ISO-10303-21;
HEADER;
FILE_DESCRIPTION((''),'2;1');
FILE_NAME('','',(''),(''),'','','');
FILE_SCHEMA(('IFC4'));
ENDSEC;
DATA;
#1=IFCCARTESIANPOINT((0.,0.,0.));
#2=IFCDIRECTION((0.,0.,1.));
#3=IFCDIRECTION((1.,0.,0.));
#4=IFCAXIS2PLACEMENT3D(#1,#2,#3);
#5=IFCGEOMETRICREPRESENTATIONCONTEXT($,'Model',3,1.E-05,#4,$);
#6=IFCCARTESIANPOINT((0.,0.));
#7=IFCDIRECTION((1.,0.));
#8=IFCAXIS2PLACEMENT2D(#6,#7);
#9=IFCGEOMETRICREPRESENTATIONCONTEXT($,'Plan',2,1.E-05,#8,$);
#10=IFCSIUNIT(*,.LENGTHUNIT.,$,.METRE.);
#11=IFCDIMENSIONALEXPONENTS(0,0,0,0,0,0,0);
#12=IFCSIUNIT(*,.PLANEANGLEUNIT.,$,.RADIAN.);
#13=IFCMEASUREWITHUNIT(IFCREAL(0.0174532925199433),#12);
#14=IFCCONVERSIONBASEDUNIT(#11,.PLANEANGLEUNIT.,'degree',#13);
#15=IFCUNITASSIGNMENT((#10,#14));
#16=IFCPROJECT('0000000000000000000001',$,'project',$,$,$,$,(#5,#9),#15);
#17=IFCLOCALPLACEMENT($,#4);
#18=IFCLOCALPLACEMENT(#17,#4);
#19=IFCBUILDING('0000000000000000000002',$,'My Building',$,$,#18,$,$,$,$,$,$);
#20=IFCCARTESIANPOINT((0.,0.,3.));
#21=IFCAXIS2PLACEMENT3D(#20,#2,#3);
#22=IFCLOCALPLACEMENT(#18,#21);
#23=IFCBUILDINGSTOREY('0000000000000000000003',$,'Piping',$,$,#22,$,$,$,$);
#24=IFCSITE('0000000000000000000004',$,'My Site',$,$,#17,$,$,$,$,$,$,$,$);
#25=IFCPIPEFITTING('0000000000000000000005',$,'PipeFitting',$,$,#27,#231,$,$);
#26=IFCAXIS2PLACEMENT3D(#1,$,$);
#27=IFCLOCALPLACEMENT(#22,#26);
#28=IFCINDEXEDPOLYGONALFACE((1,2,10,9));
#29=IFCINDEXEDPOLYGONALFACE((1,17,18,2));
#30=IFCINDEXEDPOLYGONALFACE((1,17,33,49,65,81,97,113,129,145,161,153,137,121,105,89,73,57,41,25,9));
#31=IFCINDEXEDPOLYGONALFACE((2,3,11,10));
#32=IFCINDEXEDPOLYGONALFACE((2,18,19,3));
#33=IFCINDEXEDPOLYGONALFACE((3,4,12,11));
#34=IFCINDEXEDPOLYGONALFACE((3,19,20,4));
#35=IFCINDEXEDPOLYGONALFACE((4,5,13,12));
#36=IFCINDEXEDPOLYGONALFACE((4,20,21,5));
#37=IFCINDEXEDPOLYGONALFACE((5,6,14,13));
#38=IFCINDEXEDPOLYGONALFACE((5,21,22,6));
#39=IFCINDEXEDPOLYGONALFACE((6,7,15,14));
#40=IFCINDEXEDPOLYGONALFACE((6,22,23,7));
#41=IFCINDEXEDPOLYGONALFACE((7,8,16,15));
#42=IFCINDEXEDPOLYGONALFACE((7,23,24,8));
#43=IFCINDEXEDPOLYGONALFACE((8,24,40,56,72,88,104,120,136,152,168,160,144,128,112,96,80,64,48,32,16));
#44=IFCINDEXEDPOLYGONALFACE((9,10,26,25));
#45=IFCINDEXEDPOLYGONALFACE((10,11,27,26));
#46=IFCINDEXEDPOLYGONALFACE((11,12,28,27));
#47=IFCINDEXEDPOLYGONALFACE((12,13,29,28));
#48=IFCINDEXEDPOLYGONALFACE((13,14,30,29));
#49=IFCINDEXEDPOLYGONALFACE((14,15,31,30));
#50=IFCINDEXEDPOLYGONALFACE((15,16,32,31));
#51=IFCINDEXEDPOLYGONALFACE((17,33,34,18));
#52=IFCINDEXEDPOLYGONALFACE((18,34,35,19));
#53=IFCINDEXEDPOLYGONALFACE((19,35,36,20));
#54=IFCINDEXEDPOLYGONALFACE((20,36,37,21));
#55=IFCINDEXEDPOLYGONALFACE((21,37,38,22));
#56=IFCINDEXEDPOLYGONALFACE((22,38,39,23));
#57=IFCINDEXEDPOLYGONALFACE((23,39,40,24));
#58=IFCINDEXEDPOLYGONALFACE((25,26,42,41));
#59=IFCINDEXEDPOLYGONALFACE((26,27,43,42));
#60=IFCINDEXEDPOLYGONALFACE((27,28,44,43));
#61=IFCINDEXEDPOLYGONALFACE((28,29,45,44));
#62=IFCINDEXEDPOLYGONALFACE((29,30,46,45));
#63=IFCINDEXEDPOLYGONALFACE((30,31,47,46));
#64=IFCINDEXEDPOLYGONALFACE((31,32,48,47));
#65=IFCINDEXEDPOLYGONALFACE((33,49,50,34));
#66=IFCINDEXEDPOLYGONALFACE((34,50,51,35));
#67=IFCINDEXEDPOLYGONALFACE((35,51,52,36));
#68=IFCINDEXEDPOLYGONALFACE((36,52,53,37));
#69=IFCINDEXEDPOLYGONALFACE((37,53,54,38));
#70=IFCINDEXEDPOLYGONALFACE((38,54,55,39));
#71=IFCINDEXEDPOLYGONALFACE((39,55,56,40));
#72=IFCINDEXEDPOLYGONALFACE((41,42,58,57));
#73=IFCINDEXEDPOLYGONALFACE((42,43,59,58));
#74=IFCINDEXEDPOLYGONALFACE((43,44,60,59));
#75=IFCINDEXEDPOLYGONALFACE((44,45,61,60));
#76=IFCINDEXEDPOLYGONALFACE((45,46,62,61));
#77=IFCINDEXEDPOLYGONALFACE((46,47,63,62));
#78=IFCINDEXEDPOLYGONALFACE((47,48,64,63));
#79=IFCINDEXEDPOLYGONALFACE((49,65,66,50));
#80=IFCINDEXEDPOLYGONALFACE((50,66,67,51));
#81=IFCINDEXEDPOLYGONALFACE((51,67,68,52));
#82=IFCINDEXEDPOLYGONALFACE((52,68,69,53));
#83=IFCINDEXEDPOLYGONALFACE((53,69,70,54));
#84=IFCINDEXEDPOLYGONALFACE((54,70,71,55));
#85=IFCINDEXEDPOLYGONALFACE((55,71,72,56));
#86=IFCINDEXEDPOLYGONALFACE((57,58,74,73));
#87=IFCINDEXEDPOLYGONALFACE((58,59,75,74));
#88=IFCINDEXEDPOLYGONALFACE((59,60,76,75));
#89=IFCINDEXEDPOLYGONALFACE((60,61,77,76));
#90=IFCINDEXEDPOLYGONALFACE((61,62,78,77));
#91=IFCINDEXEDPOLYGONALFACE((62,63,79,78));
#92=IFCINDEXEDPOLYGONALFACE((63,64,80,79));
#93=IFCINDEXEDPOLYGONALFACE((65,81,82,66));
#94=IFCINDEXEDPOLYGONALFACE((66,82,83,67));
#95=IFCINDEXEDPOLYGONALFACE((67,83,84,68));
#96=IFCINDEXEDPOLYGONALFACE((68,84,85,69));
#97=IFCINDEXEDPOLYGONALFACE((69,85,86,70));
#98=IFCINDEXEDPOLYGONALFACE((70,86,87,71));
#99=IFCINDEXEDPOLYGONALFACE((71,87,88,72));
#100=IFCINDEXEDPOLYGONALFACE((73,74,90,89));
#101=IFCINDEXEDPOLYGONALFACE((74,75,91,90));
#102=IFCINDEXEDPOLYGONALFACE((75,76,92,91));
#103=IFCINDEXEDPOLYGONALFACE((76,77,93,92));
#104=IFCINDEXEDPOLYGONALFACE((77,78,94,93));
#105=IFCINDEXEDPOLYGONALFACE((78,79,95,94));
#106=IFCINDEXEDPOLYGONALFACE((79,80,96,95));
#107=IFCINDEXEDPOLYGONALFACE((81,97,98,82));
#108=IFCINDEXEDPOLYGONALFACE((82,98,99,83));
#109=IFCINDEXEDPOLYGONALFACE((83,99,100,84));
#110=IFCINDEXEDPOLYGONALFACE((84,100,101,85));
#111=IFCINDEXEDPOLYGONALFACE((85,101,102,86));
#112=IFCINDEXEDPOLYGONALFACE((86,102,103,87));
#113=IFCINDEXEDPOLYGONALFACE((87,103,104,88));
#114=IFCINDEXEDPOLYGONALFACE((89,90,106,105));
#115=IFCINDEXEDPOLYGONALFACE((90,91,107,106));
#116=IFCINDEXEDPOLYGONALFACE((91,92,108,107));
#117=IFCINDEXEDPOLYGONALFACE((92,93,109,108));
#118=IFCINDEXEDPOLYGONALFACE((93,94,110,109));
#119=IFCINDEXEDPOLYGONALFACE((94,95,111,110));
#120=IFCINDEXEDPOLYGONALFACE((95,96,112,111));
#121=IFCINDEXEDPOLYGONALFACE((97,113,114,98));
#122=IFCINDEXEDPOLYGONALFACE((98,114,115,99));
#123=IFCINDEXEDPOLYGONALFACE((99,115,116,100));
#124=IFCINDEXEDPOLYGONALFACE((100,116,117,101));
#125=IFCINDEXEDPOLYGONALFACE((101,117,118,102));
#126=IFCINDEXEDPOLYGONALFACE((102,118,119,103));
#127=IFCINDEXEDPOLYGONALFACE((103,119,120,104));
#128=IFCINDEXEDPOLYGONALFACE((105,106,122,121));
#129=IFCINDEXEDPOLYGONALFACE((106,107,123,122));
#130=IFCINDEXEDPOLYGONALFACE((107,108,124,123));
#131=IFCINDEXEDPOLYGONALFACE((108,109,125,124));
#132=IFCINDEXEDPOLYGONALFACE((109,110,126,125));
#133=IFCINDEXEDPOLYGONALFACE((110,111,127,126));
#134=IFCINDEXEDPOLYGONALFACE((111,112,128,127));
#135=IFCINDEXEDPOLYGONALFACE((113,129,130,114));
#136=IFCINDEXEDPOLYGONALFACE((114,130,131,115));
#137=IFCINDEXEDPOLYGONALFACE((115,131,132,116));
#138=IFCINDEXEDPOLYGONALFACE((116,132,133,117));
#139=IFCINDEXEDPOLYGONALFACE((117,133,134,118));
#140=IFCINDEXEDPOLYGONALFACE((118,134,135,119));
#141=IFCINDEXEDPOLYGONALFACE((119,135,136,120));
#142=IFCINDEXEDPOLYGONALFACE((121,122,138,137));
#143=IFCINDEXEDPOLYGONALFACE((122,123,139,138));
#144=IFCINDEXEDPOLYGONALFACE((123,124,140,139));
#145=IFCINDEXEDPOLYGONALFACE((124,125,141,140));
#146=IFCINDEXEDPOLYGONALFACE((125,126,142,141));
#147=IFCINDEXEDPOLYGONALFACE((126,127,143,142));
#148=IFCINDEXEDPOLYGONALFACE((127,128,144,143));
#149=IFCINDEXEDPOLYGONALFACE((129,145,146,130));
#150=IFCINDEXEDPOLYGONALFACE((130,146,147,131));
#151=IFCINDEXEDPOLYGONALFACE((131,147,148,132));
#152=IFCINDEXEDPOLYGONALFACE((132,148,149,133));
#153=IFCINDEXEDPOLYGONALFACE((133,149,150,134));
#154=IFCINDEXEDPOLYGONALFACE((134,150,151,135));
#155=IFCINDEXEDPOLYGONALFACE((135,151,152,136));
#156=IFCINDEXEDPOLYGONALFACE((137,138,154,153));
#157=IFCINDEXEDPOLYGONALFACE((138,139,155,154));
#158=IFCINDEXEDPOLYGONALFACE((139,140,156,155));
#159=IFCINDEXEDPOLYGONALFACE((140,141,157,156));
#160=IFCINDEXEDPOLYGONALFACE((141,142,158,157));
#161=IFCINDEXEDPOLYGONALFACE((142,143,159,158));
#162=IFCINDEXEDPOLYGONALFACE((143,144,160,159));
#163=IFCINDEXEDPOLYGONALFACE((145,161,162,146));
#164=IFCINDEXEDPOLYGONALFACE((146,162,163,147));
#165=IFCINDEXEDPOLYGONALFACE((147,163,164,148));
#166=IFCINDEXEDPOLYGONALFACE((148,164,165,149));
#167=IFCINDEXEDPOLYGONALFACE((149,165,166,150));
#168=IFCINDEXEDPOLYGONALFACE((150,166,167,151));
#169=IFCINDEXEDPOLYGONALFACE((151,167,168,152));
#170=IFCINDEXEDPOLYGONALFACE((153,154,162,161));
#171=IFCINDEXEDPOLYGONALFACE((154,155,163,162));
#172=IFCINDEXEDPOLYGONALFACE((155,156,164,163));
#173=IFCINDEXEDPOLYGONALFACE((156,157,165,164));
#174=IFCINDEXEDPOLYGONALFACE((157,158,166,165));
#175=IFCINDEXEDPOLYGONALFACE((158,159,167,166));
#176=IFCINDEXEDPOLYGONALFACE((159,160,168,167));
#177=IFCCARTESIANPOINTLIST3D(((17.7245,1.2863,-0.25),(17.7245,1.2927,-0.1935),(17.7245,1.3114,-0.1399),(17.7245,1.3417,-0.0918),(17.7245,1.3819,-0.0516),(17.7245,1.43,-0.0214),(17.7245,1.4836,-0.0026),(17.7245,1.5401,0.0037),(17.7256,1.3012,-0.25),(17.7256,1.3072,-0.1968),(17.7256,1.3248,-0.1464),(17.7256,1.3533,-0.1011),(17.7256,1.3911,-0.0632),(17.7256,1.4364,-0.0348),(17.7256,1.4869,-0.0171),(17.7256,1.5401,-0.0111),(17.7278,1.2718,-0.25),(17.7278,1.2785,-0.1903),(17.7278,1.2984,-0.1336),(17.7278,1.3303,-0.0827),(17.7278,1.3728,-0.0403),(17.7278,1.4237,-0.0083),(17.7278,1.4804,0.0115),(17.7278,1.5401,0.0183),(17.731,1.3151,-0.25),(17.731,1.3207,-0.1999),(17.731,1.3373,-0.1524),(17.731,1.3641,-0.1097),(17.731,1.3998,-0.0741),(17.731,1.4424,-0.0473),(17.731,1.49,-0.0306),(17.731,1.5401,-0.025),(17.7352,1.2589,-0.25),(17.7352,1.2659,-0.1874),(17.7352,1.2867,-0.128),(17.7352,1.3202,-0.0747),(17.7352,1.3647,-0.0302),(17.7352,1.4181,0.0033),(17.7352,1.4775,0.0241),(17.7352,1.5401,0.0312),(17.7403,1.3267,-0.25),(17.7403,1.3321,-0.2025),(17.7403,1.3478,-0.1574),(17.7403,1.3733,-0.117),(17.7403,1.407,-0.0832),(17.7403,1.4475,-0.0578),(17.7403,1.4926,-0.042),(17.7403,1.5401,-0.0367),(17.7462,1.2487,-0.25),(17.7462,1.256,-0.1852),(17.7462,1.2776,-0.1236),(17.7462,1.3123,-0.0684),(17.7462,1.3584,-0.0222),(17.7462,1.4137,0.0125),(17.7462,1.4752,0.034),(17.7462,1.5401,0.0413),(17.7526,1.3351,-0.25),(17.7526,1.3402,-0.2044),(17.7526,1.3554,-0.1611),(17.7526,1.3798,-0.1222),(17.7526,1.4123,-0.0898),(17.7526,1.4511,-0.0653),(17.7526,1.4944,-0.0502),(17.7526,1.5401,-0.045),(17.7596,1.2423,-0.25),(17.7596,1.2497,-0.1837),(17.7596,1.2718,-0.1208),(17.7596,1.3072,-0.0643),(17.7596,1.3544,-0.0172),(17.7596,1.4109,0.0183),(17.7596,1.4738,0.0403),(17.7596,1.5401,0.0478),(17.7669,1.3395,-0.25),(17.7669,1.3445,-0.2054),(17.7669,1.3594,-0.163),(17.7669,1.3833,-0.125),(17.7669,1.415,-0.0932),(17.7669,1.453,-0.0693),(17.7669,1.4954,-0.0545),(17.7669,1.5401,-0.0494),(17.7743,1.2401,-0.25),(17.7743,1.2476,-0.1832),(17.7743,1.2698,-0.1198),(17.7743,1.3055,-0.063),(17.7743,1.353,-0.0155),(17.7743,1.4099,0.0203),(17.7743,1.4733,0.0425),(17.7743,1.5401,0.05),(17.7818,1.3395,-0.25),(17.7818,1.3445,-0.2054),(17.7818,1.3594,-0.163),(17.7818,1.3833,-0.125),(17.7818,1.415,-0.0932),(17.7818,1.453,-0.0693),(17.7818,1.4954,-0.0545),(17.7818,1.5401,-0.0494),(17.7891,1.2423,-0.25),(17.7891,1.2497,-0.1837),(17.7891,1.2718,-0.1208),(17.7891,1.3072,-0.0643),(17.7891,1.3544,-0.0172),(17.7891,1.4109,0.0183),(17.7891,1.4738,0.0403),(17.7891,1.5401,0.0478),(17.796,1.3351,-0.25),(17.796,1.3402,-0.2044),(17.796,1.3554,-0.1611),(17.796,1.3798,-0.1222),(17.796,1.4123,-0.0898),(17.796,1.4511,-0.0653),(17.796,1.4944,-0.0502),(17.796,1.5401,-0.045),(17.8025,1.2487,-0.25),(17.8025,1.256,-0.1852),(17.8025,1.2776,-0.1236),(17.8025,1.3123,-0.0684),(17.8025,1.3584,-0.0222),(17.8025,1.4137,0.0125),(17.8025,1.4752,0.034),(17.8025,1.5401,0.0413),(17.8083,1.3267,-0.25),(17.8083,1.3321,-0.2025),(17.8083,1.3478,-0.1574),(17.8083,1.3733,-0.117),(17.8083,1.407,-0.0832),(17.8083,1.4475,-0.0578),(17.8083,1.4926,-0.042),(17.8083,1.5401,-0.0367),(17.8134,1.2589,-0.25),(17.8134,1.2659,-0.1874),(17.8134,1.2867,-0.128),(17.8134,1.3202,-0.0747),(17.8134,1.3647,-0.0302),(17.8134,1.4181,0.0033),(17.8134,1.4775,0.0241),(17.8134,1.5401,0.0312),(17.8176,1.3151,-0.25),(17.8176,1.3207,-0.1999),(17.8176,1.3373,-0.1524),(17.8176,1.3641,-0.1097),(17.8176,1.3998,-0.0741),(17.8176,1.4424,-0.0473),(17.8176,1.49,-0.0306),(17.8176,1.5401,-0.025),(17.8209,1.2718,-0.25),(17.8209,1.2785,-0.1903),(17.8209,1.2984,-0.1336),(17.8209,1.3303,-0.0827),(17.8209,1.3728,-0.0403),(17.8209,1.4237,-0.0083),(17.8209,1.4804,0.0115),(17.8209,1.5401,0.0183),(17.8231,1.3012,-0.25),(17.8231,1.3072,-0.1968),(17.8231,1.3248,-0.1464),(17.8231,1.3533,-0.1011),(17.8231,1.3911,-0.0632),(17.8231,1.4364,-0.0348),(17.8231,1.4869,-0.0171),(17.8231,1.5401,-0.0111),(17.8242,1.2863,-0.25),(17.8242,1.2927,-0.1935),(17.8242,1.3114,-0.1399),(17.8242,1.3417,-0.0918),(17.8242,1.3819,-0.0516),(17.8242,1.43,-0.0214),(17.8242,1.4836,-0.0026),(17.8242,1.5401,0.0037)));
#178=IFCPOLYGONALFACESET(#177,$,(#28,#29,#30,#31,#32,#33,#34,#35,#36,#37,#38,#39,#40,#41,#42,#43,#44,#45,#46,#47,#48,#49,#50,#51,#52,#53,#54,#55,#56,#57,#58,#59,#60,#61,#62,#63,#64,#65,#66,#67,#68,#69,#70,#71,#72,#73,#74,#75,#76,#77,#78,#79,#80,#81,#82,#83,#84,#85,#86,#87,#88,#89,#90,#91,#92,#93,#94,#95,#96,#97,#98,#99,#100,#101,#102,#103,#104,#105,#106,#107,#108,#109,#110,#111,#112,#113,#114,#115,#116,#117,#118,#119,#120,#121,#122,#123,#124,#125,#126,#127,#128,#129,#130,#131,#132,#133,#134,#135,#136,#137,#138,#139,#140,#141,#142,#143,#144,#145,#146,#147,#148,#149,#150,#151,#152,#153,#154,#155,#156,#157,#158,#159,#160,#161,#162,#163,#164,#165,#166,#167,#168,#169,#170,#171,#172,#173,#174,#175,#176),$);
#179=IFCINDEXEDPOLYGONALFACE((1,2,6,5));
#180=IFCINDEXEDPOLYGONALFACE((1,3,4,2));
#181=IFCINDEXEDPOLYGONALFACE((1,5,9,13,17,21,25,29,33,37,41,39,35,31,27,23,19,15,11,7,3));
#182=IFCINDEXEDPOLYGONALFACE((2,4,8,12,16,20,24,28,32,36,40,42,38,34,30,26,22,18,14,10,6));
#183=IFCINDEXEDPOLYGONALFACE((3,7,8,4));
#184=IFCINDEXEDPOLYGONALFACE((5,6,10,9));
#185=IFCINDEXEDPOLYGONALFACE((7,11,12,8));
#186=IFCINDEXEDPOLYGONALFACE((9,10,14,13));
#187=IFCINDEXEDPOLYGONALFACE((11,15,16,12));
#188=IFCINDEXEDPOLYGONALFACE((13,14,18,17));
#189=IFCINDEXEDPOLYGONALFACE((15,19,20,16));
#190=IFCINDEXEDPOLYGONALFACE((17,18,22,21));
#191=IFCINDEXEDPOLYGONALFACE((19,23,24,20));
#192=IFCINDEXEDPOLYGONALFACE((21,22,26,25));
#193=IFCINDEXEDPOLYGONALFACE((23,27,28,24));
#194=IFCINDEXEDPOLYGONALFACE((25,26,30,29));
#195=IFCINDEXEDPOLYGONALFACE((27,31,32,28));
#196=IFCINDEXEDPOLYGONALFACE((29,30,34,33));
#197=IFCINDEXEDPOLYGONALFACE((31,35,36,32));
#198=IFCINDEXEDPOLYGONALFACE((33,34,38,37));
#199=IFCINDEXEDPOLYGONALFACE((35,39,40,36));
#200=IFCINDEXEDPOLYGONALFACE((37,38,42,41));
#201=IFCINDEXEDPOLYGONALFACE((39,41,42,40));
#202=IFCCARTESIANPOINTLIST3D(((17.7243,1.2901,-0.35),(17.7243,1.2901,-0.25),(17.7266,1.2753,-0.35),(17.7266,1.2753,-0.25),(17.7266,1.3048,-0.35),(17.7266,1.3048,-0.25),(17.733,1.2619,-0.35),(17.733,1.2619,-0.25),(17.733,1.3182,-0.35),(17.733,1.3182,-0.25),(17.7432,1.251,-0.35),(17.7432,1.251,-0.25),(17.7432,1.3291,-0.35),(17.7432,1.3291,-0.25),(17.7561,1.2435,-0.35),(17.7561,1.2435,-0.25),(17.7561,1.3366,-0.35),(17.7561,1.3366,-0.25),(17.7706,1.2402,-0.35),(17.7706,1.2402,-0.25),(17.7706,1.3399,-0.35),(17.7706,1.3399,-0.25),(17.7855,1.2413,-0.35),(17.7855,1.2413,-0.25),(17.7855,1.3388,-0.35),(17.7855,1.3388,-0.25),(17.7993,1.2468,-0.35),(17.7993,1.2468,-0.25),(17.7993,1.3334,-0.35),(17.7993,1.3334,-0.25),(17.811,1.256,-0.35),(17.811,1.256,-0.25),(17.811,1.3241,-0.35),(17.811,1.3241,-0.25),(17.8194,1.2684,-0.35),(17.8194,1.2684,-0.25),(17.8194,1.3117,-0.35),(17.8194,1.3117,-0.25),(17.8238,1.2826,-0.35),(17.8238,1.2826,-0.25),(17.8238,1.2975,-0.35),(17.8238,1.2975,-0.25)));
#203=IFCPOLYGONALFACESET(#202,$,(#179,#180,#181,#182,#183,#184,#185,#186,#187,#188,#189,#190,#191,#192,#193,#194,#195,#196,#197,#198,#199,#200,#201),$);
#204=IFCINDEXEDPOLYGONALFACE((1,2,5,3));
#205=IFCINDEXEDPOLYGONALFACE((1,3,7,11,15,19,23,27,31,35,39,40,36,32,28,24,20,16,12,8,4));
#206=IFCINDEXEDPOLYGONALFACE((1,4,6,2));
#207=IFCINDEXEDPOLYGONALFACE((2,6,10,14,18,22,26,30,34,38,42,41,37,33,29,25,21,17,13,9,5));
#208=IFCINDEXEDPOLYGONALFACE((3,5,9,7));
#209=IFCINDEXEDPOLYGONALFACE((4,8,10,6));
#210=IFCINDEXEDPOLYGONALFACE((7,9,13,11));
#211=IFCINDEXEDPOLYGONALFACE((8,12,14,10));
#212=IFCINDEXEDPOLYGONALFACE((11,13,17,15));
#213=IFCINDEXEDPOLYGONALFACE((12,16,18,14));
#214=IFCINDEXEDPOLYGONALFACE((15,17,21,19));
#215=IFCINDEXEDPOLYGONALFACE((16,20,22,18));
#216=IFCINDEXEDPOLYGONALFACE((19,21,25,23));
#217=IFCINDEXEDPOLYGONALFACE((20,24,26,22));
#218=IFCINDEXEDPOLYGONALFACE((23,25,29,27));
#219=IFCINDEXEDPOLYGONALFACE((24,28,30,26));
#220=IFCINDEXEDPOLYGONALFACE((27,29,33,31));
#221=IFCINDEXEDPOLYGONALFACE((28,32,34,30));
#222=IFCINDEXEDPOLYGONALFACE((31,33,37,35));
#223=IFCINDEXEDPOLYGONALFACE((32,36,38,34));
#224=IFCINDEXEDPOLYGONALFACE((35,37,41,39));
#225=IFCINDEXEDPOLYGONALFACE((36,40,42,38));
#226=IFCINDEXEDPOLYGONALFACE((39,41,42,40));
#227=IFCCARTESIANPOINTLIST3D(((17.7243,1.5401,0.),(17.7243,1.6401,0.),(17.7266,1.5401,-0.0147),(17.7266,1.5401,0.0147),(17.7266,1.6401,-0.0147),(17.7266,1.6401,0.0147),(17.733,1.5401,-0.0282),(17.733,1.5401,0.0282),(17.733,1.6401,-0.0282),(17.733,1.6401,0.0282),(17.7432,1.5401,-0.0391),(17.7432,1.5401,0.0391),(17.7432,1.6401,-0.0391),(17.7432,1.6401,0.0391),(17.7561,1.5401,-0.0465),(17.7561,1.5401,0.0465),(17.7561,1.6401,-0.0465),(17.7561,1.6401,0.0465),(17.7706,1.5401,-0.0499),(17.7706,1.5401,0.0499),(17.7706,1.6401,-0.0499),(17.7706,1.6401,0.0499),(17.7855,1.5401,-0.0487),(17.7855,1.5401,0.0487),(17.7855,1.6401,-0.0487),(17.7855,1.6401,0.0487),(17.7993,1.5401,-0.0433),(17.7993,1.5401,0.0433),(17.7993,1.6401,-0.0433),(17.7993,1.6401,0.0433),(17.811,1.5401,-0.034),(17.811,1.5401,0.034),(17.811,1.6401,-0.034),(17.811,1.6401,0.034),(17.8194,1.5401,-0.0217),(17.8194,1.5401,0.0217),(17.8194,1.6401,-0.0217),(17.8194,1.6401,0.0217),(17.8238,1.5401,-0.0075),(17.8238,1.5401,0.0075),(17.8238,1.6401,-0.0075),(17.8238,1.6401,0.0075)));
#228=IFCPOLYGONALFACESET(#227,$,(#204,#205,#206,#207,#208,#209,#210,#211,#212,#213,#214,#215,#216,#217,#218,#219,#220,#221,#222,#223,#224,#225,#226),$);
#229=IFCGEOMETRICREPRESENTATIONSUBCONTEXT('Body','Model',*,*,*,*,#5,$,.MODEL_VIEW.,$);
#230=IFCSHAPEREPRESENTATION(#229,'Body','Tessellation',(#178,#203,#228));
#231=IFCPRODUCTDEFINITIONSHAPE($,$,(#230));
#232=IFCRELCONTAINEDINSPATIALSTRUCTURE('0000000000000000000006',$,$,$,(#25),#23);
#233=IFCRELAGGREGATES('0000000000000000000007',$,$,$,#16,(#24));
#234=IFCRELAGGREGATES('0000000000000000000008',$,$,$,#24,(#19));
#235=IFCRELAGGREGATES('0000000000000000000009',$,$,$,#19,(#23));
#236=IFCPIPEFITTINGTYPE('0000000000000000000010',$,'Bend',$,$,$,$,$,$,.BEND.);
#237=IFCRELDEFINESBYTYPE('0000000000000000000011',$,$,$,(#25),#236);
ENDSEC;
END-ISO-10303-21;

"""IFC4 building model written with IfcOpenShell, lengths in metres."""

from ifc_helpers import new_model, entity, si_unit, converted_unit, frame, origin_with_axes, origin_2d_with_axis, place, context, subcontext, project, spatial, circle, extrude, source, transform, mapped, type_object, type_shapes, element, save


model = new_model("IFC4")

# Units and contexts
model_context = context("Model", 3, precision=1e-05, world=origin_with_axes())
plan_context = context("Plan", 2, precision=1e-05, world=origin_2d_with_axis())
body_context = subcontext(model_context, "Body", "Model", "MODEL_VIEW")
ifc_project = project(units=[si_unit("LENGTHUNIT", "METRE"), converted_unit("PLANEANGLEUNIT", "degree", entity("IfcReal", 0.0174532925199433), si_unit("PLANEANGLEUNIT", "RADIAN"), dimensions=[0, 0, 0, 0, 0, 0, 0])], contexts=[model_context, plan_context])

# Site, building, storey
site_placement = place(None, origin_with_axes())
site = spatial("IfcSite", under=ifc_project, at=site_placement, Name="My Site")
building_placement = place(site_placement, origin_with_axes())
building = spatial("IfcBuilding", under=site, at=building_placement, Name="My Building")
storey_placement = place(building_placement, frame((0.0, 0.0, 3.0), z_axis=(0.0, 0.0, 1.0), x_axis=(1.0, 0.0, 0.0)))
storey = spatial("IfcBuildingStorey", under=building, at=storey_placement, Name="Piping")

# Pipe fitting
pipe_fitting_type_1 = type_object("IfcPipeFittingType", Name="Bend", PredefinedType="BEND")
shared_shape = source(origin_with_axes(), body_context, "Body", "SolidModel", [
    entity("IfcSweptDiskSolid", entity("IfcIndexedPolyCurve", entity("IfcCartesianPointList3D", [[0.0, 0.0, -0.1], [0.0, 0.0732, -0.2768], [0.0, 0.25, -0.35]]), [entity("IfcArcIndex", [1, 2, 3])]), 0.05),
    extrude(circle(Radius=0.05), origin_with_axes(), (0.0, 0.0, -1.0), 0.1),
    extrude(circle(Radius=0.05), frame((0.0, 0.25, -0.35), z_axis=(0.0, 1.0, 0.0), x_axis=(1.0, 0.0, 0.0)), (0.0, 0.0, 1.0), 0.1),
])
type_shapes(pipe_fitting_type_1, [shared_shape])
for number, where, z_axis, x_axis, name in (
    (1, (17.7743, 1.2901, -0.35), (0.0, 0.0, -1.0), (-1.0, 0.0, 0.0), "PipeFitting"),
):
    element("IfcPipeFitting", number, at=place(storey_placement, frame(where, z_axis=z_axis, x_axis=x_axis)), inside=storey, type_object=pipe_fitting_type_1, Name=name, context=body_context, shape_type="MappedRepresentation", body=[
        mapped(shared_shape, transform((0.0, 0.0, 0.0), x_axis=(1.0, 0.0, 0.0), y_axis=(0.0, 1.0, 0.0), z_axis=(0.0, 0.0, 1.0), scale=1.0)),
    ])

save(model, "model.ifc")
